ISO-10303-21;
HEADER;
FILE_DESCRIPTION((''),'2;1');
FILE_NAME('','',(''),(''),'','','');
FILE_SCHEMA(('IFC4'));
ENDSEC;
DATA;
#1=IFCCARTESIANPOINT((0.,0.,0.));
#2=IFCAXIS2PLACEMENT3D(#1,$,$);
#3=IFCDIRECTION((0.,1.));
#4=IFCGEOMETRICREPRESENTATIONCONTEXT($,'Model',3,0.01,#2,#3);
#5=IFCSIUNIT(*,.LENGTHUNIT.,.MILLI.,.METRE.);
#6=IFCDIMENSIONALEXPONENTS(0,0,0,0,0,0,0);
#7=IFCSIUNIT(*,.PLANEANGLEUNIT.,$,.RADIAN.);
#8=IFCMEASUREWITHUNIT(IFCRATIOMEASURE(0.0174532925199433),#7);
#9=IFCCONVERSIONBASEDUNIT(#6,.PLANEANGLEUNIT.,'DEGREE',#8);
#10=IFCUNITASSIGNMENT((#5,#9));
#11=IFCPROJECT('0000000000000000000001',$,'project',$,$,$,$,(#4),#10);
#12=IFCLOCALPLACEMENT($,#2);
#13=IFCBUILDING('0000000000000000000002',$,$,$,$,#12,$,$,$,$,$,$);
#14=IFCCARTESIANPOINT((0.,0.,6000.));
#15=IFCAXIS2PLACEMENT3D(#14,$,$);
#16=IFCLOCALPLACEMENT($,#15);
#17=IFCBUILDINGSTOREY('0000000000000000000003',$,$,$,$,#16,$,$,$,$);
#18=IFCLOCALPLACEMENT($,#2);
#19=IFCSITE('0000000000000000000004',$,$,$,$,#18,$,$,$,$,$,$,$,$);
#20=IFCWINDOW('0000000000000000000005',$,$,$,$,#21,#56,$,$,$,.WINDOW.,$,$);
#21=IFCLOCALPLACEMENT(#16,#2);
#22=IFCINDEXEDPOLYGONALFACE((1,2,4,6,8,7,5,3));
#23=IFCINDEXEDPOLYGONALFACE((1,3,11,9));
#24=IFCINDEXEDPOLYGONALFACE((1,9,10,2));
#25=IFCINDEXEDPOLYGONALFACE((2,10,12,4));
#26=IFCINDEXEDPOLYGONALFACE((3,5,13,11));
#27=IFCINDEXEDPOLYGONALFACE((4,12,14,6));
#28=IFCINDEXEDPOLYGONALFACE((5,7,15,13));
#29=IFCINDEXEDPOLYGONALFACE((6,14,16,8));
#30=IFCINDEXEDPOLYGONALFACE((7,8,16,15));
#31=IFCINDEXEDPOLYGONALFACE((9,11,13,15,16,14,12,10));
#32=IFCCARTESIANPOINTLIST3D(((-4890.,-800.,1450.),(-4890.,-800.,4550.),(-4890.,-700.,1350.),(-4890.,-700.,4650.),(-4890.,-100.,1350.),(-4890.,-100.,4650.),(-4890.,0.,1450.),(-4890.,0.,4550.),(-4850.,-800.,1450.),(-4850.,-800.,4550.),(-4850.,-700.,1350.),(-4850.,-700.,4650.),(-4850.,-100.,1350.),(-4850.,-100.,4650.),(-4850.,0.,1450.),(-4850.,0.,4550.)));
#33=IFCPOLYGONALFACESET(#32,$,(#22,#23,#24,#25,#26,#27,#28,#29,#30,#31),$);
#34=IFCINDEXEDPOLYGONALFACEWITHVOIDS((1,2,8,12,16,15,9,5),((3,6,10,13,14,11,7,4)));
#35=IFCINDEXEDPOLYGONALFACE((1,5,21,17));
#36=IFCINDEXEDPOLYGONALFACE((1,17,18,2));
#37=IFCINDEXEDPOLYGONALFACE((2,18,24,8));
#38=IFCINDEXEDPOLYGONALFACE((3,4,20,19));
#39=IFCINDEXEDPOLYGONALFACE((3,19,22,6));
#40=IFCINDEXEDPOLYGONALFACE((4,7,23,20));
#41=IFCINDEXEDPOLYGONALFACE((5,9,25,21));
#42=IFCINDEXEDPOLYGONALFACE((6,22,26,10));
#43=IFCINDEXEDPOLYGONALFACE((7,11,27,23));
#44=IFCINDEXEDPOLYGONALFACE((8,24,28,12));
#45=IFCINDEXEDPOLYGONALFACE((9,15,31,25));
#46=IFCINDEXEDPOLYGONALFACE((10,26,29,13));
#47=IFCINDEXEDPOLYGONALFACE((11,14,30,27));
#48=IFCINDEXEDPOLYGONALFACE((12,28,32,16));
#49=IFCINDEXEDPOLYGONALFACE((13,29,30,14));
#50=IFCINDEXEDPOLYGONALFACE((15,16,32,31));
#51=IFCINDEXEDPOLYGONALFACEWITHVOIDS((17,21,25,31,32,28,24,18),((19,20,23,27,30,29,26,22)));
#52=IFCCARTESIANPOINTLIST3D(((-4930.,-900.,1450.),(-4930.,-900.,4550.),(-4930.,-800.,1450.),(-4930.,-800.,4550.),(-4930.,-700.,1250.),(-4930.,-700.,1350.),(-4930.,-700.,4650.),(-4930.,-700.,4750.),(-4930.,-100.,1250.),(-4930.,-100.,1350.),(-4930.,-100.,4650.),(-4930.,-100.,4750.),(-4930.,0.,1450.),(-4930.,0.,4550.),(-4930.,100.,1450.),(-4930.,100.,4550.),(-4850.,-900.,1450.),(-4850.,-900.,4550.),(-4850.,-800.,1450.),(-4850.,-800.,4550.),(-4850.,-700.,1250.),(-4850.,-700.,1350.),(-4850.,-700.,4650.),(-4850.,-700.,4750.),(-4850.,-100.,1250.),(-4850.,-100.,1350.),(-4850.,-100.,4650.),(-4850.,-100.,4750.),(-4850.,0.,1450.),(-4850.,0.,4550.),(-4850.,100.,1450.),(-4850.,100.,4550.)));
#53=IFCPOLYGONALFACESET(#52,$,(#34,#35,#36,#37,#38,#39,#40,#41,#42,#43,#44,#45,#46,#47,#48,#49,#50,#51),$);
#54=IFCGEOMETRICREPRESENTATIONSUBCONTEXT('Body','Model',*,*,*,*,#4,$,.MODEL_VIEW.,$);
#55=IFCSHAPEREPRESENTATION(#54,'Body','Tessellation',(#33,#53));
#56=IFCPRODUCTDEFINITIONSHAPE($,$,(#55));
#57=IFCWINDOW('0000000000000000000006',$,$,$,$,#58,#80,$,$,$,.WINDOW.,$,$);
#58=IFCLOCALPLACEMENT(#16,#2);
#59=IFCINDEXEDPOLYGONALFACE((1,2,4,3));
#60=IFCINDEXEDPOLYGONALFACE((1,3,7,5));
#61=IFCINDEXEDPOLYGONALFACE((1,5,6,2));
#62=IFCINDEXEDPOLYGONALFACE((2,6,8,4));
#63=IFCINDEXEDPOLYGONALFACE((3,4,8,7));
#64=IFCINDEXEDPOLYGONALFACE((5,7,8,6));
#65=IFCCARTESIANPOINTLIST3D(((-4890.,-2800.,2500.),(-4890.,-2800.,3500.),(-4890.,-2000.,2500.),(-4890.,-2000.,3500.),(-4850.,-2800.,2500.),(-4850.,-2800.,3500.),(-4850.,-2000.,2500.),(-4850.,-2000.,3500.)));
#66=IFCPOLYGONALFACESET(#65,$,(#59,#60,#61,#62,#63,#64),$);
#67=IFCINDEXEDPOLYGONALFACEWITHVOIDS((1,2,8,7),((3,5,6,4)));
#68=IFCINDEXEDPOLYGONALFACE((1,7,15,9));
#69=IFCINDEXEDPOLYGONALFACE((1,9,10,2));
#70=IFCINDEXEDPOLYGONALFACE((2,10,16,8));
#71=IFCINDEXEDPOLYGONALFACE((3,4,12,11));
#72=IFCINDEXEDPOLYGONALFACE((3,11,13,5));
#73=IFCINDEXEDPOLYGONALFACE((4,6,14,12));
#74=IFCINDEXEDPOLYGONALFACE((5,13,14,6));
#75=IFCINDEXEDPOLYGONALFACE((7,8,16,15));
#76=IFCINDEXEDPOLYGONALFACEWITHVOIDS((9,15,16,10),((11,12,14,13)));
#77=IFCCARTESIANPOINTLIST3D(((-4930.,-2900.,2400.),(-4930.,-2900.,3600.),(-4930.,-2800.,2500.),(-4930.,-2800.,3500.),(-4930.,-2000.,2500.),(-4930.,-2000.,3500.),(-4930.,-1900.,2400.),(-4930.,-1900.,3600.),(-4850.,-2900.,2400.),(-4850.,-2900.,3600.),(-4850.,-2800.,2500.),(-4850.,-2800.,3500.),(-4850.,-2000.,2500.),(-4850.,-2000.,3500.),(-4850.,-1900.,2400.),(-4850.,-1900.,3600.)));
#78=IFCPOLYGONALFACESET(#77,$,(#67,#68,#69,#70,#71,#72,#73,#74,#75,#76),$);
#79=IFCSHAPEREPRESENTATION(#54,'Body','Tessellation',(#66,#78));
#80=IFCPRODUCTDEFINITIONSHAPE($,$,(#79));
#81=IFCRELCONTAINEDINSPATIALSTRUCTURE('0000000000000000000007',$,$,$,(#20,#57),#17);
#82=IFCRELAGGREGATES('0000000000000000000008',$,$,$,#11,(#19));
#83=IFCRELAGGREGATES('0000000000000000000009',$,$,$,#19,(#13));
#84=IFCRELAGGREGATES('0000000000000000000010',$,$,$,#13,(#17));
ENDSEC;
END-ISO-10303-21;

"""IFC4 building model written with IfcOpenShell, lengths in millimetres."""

from ifc_helpers import new_model, entity, si_unit, converted_unit, direction, frame, origin, place, context, subcontext, project, spatial, element, save


model = new_model("IFC4")

# Units and contexts
model_context = context("Model", 3, precision=0.01, world=origin(), true_north=direction((0.0, 1.0)))
body_context = subcontext(model_context, "Body", "Model", "MODEL_VIEW")
ifc_project = project(units=[si_unit("LENGTHUNIT", "METRE", prefix="MILLI"), converted_unit("PLANEANGLEUNIT", "DEGREE", entity("IfcRatioMeasure", 0.0174532925199433), si_unit("PLANEANGLEUNIT", "RADIAN"), dimensions=[0, 0, 0, 0, 0, 0, 0])], contexts=[model_context])

# Site, building, storey
site_placement = place(None, origin())
site = spatial("IfcSite", under=ifc_project, at=site_placement)
building_placement = place(None, origin())
building = spatial("IfcBuilding", under=site, at=building_placement)
storey_placement = place(None, frame((0.0, 0.0, 6000.0)))
storey = spatial("IfcBuildingStorey", under=building, at=storey_placement)

# Shared definitions
cartesian_point_1 = entity("IfcCartesianPoint", [-400.0, -1550.0])
shared_polyline_1 = entity("IfcPolyline", [cartesian_point_1, entity("IfcCartesianPoint", [-400.0, 1550.0]), entity("IfcCartesianPoint", [-300.0, 1650.0]), entity("IfcCartesianPoint", [300.0, 1650.0]), entity("IfcCartesianPoint", [400.0, 1550.0]), entity("IfcCartesianPoint", [400.0, -1550.0]), entity("IfcCartesianPoint", [300.0, -1650.0]), entity("IfcCartesianPoint", [-300.0, -1650.0]), cartesian_point_1])
cartesian_point_2 = entity("IfcCartesianPoint", [-400.0, -500.0])
shared_polyline_2 = entity("IfcPolyline", [cartesian_point_2, entity("IfcCartesianPoint", [-400.0, 500.0]), entity("IfcCartesianPoint", [-400.0, 500.0]), entity("IfcCartesianPoint", [400.0, 500.0]), entity("IfcCartesianPoint", [400.0, 500.0]), entity("IfcCartesianPoint", [400.0, -500.0]), entity("IfcCartesianPoint", [400.0, -500.0]), entity("IfcCartesianPoint", [-400.0, -500.0]), cartesian_point_2])

# Shared definitions
wall_1_placement = place(storey_placement, frame((-4900.0, 100.0, 0.0), z_axis=(0.0, 0.0, 1.0), x_axis=(0.0, -1.0, 0.0)))
window_1_placement = place(wall_1_placement, frame((500.0, 50.0, 3000.0)))
window_2_placement = place(wall_1_placement, frame((2500.0, 50.0, 3000.0)))

# Windows
cartesian_point_3 = entity("IfcCartesianPoint", [-500.0, -1550.0])
element("IfcWindow", 1, at=window_1_placement, inside=storey, PredefinedType="WINDOW", context=body_context, shape_type="SweptSolid", body=[
    entity("IfcExtrudedAreaSolid", entity("IfcArbitraryClosedProfileDef", "AREA", None, shared_polyline_1), entity("IfcAxis2Placement3D", entity("IfcCartesianPoint", [0.0, 0.0, 0.0]), entity("IfcDirection", [0.0, -1.0, 0.0]), entity("IfcDirection", [1.0, 0.0, 0.0])), entity("IfcDirection", [0.0, 0.0, 1.0]), 40.0),
    entity("IfcExtrudedAreaSolid", entity("IfcArbitraryProfileDefWithVoids", "AREA", None, entity("IfcPolyline", [cartesian_point_3, entity("IfcCartesianPoint", [-500.0, 1550.0]), entity("IfcCartesianPoint", [-300.0, 1750.0]), entity("IfcCartesianPoint", [300.0, 1750.0]), entity("IfcCartesianPoint", [500.0, 1550.0]), entity("IfcCartesianPoint", [500.0, -1550.0]), entity("IfcCartesianPoint", [300.0, -1750.0]), entity("IfcCartesianPoint", [-300.0, -1750.0]), cartesian_point_3]), [shared_polyline_1]), entity("IfcAxis2Placement3D", entity("IfcCartesianPoint", [0.0, 0.0, 0.0]), entity("IfcDirection", [0.0, -1.0, 0.0]), entity("IfcDirection", [1.0, 0.0, 0.0])), entity("IfcDirection", [0.0, 0.0, 1.0]), 80.0),
])
cartesian_point_4 = entity("IfcCartesianPoint", [-500.0, -600.0])
element("IfcWindow", 2, at=window_2_placement, inside=storey, PredefinedType="WINDOW", context=body_context, shape_type="SweptSolid", body=[
    entity("IfcExtrudedAreaSolid", entity("IfcArbitraryClosedProfileDef", "AREA", None, shared_polyline_2), entity("IfcAxis2Placement3D", entity("IfcCartesianPoint", [0.0, 0.0, 0.0]), entity("IfcDirection", [0.0, -1.0, 0.0]), entity("IfcDirection", [1.0, 0.0, 0.0])), entity("IfcDirection", [0.0, 0.0, 1.0]), 40.0),
    entity("IfcExtrudedAreaSolid", entity("IfcArbitraryProfileDefWithVoids", "AREA", None, entity("IfcPolyline", [cartesian_point_4, entity("IfcCartesianPoint", [-500.0, 600.0]), entity("IfcCartesianPoint", [-500.0, 600.0]), entity("IfcCartesianPoint", [500.0, 600.0]), entity("IfcCartesianPoint", [500.0, 600.0]), entity("IfcCartesianPoint", [500.0, -600.0]), entity("IfcCartesianPoint", [500.0, -600.0]), entity("IfcCartesianPoint", [-500.0, -600.0]), cartesian_point_4]), [shared_polyline_2]), entity("IfcAxis2Placement3D", entity("IfcCartesianPoint", [0.0, 0.0, 0.0]), entity("IfcDirection", [0.0, -1.0, 0.0]), entity("IfcDirection", [1.0, 0.0, 0.0])), entity("IfcDirection", [0.0, 0.0, 1.0]), 80.0),
])

save(model, "model.ifc")
